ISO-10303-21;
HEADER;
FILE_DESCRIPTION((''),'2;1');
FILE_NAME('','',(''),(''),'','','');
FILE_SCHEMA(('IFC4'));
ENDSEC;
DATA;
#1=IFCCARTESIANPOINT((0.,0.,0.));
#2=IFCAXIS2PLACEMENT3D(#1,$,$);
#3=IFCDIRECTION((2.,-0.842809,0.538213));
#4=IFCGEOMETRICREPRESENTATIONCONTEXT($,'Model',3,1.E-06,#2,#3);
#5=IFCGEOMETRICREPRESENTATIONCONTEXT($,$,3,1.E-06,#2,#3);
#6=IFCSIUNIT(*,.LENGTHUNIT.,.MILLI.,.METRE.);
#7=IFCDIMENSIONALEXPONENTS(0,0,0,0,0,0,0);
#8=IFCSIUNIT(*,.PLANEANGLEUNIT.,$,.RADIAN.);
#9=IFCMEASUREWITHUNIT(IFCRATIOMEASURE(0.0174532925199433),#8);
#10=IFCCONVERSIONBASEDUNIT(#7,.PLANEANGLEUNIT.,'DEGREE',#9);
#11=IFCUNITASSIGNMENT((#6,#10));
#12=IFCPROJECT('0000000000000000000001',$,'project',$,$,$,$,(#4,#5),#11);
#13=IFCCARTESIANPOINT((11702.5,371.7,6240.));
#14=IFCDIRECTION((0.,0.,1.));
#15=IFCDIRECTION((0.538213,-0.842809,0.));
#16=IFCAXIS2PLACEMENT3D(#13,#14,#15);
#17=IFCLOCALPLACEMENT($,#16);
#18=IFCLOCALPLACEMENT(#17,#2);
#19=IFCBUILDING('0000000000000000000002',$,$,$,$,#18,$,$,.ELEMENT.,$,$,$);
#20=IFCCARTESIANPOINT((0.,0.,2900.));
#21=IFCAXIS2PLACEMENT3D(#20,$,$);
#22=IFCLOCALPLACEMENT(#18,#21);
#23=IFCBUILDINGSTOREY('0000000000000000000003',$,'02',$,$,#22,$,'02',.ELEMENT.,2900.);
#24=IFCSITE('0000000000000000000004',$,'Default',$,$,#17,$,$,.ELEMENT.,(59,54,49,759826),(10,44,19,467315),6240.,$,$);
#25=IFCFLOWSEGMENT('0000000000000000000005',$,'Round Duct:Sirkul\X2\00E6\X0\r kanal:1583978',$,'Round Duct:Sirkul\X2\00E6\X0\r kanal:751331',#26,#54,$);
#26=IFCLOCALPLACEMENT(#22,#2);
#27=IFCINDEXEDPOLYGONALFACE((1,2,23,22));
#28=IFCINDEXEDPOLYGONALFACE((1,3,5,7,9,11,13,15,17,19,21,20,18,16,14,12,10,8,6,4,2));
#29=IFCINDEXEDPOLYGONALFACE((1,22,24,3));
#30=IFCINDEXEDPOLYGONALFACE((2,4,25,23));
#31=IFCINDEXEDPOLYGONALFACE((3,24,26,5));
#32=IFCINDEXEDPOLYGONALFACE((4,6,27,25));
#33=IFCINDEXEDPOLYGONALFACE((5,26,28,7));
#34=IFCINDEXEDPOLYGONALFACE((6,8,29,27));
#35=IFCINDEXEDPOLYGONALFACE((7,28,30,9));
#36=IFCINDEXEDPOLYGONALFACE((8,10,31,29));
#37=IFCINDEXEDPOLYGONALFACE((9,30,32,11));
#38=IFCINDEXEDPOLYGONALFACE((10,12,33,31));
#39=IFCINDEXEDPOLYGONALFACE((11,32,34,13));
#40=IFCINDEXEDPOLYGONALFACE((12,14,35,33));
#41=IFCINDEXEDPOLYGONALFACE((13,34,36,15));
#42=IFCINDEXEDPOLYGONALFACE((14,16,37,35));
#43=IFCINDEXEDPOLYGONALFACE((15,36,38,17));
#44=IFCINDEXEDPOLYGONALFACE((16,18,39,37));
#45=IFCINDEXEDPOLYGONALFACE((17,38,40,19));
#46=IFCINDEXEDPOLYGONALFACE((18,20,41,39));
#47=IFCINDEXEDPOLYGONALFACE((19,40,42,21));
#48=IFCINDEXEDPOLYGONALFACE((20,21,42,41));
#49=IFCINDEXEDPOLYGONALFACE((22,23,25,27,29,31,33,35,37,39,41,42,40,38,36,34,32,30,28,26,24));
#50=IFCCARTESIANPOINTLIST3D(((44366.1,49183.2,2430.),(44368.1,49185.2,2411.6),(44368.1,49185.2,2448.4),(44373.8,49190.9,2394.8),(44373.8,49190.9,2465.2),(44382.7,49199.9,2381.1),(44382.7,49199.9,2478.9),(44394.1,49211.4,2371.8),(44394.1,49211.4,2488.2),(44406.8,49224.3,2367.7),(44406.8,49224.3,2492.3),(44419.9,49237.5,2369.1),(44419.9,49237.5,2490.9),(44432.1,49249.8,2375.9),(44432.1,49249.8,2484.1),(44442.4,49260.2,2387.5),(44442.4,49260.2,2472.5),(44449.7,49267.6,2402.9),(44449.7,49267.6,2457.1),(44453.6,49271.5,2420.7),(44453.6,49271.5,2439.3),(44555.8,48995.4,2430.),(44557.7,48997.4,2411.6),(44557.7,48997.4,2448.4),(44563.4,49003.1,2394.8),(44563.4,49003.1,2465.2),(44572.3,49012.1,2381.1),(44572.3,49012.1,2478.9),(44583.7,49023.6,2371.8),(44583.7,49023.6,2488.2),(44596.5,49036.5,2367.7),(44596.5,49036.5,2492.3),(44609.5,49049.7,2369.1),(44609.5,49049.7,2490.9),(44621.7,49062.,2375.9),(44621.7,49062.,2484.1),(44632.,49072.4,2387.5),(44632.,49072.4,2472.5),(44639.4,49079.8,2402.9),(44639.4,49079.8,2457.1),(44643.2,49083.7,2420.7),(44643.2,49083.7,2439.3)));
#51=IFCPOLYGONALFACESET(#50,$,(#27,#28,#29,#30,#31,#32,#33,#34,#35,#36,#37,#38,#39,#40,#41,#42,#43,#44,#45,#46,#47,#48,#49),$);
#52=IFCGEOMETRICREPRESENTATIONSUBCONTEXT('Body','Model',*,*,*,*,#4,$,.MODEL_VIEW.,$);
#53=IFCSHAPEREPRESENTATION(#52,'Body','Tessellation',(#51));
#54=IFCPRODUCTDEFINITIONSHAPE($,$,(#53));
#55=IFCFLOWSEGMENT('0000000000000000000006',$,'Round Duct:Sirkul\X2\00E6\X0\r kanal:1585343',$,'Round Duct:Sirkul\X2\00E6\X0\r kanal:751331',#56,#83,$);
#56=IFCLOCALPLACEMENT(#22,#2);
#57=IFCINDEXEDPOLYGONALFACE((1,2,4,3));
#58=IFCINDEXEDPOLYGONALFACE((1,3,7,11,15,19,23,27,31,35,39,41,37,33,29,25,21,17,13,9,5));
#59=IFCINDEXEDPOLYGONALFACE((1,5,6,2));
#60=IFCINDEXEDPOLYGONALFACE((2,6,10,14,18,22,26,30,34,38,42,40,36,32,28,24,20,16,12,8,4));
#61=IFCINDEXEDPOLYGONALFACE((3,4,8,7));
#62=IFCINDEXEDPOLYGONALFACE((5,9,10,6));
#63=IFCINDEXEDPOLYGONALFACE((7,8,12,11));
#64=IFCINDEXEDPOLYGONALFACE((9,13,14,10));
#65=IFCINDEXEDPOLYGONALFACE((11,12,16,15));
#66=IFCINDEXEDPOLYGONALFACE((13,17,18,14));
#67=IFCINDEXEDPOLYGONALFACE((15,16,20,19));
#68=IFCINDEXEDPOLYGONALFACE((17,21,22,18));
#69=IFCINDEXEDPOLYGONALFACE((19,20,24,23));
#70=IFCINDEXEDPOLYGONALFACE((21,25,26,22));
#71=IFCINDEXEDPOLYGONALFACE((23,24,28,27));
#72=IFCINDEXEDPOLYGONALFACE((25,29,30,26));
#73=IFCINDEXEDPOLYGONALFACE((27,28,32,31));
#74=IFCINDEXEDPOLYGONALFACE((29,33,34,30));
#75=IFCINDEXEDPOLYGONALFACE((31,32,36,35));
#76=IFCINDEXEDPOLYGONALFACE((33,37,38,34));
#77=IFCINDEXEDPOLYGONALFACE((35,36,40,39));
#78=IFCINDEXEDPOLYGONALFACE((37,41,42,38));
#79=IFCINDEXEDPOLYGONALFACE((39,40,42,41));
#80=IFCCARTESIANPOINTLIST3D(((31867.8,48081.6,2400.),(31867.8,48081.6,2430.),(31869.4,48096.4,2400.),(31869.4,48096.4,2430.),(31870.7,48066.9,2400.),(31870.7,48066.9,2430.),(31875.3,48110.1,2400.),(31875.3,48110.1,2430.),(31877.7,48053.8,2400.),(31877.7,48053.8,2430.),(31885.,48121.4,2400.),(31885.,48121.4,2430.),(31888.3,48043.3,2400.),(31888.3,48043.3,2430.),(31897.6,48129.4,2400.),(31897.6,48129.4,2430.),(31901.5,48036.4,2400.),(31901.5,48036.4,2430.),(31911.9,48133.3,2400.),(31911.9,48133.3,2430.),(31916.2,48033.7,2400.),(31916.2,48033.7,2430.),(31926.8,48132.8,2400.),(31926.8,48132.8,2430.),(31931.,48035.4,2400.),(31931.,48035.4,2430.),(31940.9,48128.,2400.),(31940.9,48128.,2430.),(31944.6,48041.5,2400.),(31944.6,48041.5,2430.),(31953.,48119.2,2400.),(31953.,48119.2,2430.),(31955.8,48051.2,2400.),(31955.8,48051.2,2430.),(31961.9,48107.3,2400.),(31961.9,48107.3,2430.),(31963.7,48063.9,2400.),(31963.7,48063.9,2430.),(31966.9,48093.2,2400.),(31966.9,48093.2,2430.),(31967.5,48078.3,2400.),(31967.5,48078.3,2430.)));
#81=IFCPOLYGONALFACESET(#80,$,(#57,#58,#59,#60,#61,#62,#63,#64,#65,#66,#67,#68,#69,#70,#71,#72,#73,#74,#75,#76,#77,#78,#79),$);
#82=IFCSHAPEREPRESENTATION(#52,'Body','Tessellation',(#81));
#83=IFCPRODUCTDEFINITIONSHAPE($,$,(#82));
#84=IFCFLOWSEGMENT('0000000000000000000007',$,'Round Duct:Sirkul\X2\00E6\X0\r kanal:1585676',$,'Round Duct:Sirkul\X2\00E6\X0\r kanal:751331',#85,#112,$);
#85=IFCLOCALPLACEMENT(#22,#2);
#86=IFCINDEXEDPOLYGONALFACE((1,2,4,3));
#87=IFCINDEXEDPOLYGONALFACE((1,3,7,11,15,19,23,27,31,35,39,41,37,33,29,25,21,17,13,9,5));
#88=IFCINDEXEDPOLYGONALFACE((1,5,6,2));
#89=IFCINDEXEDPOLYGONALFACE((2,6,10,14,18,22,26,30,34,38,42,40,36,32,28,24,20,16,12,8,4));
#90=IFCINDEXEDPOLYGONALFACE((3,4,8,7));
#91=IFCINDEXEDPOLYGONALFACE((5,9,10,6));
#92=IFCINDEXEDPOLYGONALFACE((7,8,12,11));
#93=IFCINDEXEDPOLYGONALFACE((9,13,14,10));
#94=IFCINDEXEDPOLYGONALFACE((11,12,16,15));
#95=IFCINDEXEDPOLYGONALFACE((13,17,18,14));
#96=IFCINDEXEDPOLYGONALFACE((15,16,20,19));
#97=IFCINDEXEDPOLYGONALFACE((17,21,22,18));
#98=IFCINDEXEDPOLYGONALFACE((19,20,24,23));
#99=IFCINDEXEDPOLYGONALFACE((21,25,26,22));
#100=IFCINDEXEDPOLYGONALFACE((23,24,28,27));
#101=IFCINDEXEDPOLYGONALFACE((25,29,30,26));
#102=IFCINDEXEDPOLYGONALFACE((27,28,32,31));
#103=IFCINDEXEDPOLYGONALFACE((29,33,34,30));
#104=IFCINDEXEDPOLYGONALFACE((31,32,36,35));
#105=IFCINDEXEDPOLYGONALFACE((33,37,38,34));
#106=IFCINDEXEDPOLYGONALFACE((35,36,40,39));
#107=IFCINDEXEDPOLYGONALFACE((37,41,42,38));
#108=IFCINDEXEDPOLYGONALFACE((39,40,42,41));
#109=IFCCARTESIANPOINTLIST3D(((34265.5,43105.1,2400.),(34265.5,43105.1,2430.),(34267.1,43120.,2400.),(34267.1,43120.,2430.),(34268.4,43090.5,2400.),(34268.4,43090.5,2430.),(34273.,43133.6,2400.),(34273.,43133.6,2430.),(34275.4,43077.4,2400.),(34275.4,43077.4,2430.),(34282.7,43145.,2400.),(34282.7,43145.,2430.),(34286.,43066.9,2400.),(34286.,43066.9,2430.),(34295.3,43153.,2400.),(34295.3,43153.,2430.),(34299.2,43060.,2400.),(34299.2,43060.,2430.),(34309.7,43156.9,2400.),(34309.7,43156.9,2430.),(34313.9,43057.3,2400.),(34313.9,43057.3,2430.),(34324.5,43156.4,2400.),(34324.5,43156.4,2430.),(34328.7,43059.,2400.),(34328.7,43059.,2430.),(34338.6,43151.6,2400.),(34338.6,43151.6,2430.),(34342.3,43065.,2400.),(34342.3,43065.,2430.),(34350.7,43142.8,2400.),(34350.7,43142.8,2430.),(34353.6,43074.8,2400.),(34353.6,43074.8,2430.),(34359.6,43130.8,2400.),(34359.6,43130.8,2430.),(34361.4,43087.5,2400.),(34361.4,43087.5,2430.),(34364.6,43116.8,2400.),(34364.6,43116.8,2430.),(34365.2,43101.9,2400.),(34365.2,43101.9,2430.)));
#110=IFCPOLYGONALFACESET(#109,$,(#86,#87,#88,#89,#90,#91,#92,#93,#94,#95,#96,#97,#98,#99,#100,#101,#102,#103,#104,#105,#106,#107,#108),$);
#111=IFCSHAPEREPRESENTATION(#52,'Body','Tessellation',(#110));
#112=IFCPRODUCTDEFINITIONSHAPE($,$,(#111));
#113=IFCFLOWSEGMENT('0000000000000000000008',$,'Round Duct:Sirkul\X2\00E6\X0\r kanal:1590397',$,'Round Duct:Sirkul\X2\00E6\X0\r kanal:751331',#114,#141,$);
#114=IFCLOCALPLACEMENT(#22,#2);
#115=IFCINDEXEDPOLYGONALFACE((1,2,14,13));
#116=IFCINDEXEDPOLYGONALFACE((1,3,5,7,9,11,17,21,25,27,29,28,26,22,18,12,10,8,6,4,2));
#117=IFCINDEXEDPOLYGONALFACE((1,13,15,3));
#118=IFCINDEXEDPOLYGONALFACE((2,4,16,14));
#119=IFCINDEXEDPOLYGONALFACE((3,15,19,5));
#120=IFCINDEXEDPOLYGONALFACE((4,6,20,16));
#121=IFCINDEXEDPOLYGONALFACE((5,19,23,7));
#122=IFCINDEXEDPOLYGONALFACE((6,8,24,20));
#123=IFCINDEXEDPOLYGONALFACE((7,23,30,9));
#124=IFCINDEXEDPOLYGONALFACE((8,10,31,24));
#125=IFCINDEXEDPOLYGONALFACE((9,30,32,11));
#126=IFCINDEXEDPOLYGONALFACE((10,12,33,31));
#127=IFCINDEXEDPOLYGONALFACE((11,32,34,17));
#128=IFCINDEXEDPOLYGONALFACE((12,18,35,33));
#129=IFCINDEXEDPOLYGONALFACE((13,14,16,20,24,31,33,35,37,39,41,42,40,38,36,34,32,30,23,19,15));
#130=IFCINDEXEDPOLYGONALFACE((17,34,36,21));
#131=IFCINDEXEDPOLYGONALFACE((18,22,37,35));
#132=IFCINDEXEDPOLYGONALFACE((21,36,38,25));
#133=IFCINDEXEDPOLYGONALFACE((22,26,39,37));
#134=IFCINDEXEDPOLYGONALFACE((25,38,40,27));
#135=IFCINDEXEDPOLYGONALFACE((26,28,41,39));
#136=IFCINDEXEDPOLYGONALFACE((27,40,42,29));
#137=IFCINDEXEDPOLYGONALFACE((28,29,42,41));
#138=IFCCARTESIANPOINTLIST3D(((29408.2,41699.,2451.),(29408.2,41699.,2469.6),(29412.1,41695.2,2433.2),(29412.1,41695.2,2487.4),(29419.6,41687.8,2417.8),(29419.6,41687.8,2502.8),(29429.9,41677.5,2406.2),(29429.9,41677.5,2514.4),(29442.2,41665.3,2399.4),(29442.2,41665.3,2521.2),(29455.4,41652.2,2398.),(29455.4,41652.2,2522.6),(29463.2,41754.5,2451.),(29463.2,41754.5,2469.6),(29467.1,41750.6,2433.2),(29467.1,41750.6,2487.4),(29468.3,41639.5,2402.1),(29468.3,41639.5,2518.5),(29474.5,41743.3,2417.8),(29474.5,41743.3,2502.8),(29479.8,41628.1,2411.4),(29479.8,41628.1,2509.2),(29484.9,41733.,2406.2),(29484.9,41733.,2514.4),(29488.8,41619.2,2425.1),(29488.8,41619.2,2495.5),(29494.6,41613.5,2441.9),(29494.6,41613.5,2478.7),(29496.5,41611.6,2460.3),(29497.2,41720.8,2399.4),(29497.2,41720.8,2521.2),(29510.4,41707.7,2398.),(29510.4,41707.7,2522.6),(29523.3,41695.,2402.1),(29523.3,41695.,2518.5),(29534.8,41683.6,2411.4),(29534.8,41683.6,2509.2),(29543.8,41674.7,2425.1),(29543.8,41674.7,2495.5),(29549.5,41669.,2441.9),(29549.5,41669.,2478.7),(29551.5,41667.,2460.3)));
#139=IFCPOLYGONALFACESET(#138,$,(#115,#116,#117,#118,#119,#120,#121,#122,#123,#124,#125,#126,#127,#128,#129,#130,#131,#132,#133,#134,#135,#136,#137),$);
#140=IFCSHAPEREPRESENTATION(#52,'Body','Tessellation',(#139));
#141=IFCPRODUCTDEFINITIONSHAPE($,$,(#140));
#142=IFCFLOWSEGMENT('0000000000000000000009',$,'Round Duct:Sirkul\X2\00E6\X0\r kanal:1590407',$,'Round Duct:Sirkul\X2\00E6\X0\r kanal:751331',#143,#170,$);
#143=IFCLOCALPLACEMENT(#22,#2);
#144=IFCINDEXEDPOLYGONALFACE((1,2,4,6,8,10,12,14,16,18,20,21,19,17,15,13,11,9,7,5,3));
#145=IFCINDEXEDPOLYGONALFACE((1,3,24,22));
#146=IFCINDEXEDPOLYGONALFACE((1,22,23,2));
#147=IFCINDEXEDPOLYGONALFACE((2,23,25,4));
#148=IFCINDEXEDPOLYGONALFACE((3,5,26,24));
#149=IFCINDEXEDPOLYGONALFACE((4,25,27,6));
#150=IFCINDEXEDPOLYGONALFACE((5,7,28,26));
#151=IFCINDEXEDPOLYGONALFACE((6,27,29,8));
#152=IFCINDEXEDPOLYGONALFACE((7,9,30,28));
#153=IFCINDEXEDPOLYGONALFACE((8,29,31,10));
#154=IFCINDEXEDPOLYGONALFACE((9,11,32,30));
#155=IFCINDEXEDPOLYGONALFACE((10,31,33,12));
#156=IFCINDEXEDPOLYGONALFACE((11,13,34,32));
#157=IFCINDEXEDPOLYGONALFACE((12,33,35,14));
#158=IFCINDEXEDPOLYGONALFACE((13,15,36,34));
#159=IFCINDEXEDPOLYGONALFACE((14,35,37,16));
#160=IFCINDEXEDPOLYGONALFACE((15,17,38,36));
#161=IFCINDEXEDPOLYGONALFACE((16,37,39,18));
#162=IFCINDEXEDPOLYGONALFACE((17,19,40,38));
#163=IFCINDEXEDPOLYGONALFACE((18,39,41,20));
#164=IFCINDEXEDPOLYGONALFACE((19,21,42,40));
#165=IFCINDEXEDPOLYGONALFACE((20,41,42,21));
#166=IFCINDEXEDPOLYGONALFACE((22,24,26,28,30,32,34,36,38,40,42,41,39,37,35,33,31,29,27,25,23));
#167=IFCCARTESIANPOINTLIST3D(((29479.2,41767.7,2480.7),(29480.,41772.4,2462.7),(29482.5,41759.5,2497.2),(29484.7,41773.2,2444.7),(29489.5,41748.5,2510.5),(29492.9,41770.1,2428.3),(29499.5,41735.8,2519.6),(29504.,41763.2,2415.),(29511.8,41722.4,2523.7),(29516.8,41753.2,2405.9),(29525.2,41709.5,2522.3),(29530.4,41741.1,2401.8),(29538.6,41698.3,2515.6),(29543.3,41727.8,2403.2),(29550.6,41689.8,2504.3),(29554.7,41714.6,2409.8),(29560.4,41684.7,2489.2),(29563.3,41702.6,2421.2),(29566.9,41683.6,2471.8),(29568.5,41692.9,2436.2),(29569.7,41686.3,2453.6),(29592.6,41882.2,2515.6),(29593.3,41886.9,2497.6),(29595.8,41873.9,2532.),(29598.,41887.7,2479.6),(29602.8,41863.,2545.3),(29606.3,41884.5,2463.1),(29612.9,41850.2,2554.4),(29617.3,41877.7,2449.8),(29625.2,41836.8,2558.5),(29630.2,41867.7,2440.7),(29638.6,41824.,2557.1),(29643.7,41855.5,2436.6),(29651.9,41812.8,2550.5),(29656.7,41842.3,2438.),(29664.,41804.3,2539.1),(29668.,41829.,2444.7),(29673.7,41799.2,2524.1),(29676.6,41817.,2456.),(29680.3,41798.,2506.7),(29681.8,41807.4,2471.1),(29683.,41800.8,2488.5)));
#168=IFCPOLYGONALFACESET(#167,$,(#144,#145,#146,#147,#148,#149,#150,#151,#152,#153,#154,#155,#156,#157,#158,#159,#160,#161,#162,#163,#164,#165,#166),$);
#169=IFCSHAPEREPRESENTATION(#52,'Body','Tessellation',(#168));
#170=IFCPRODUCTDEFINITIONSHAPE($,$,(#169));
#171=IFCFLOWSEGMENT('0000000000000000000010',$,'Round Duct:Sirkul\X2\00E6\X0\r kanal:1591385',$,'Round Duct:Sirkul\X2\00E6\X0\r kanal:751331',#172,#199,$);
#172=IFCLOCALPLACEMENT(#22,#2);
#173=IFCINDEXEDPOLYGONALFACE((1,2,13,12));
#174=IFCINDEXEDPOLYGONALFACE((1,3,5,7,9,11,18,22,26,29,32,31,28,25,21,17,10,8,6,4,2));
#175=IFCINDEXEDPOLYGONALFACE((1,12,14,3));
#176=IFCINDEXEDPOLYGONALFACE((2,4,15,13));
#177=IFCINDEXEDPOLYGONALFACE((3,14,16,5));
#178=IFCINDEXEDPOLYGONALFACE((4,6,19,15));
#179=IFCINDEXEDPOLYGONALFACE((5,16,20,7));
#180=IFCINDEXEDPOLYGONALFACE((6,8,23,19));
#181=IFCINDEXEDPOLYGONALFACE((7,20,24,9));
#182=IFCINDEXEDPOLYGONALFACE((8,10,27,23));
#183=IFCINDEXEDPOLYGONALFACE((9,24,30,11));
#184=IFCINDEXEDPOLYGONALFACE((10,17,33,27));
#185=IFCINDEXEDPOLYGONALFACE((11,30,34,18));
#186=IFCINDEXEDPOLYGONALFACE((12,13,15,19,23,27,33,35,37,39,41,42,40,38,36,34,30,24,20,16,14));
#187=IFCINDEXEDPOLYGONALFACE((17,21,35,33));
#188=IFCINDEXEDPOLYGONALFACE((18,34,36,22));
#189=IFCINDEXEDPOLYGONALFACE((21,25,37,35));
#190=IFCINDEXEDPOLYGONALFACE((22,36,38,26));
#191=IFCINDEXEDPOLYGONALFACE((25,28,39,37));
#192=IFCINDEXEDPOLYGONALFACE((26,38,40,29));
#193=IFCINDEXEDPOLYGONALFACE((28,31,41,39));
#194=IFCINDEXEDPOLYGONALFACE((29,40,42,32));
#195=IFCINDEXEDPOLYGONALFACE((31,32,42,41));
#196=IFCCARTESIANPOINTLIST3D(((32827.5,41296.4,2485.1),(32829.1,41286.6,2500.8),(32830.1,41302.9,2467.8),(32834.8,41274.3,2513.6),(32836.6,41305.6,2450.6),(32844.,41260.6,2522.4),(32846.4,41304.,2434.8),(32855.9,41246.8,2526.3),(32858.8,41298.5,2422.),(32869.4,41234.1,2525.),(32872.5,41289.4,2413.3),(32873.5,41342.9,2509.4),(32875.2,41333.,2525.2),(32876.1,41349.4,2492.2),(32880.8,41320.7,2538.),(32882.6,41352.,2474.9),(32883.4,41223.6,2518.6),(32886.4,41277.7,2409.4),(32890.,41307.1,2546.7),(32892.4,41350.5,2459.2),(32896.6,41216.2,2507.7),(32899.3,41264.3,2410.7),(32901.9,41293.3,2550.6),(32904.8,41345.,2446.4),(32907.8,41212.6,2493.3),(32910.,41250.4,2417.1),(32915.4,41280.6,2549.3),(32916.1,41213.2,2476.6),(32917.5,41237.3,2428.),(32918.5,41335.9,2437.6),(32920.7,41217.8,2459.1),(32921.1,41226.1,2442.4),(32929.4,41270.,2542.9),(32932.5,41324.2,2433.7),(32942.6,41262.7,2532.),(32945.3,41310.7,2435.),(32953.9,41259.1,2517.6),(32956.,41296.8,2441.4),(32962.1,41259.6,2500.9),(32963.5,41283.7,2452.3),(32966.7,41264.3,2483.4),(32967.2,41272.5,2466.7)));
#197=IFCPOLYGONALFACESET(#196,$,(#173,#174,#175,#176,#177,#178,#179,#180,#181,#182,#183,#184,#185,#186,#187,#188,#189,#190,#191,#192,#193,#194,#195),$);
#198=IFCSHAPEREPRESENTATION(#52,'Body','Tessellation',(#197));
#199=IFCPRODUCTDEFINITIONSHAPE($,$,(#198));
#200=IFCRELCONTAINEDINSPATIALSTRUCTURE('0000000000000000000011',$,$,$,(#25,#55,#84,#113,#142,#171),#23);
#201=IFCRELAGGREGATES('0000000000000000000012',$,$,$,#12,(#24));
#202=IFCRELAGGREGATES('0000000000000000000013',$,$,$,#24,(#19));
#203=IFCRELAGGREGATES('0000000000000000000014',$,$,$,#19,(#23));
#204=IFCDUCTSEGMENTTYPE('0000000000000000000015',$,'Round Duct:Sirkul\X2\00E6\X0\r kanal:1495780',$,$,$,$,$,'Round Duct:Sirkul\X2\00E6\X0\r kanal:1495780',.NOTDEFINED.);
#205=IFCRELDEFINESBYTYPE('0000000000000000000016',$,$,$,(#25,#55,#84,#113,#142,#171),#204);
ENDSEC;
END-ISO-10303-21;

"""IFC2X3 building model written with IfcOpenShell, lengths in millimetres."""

from ifc_helpers import new_model, entity, si_unit, converted_unit, direction, frame, frame_2d, origin, origin_2d_with_axis, place, context, subcontext, project, spatial, circle, extrude, type_object, element, save


model = new_model("IFC2X3")

# Units and contexts
model_context = context("Model", 3, precision=1e-06, world=origin(), true_north=direction((2.0, -0.842809, 0.538213)))
context_of_model = context(None, 3, precision=1e-06, world=origin(), true_north=direction((2.0, -0.842809, 0.538213)))
body_context = subcontext(model_context, "Body", "Model", "MODEL_VIEW")
ifc_project = project(units=[si_unit("LENGTHUNIT", "METRE", prefix="MILLI"), converted_unit("PLANEANGLEUNIT", "DEGREE", entity("IfcRatioMeasure", 0.0174532925199433), si_unit("PLANEANGLEUNIT", "RADIAN"), dimensions=[0, 0, 0, 0, 0, 0, 0])], contexts=[model_context, context_of_model])

# Site, building, storey
site_placement = place(None, frame((11702.5, 371.7, 6240.0), z_axis=(0.0, 0.0, 1.0), x_axis=(0.538213, -0.842809, 0.0)))
site = spatial("IfcSite", under=ifc_project, at=site_placement, Name="Default", CompositionType="ELEMENT", RefLatitude=(59, 54, 49, 759826), RefLongitude=(10, 44, 19, 467315), RefElevation=6240.0)
building_placement = place(site_placement, origin())
building = spatial("IfcBuilding", under=site, at=building_placement, CompositionType="ELEMENT")
storey_placement = place(building_placement, frame((0.0, 0.0, 2900.0)))
storey = spatial("IfcBuildingStorey", under=building, at=storey_placement, Name="02", LongName="02", CompositionType="ELEMENT", Elevation=2900.0)

# Flow segments
duct_segment_type = type_object("IfcDuctSegmentType", Name="Round Duct:Sirkulær kanal:1495780", ElementType="Round Duct:Sirkulær kanal:1495780", PredefinedType="NOTDEFINED")
flow_segment_1_placement = place(storey_placement, origin())
element("IfcFlowSegment", 1, at=flow_segment_1_placement, inside=storey, type_object=duct_segment_type, Name="Round Duct:Sirkulær kanal:1583978", ObjectType="Round Duct:Sirkulær kanal:751331", context=body_context, shape_type="SweptSolid", body=[
    extrude(circle(Radius=62.5, at=origin_2d_with_axis()), frame((44410.1, 49227.6, 2430.0), z_axis=(0.710534, -0.703662, 0.0), x_axis=(-0.703662, -0.710534, 0.0)), (0.0, 0.0, 1.0), 266.9),
])
flow_segment_2_placement = place(storey_placement, origin())
element("IfcFlowSegment", 2, at=flow_segment_2_placement, inside=storey, type_object=duct_segment_type, Name="Round Duct:Sirkulær kanal:1585343", ObjectType="Round Duct:Sirkulær kanal:751331", context=body_context, shape_type="SweptSolid", body=[
    extrude(circle(Radius=50.0, at=frame_2d((0.0, 0.0), x_axis=(1.0, 0.0))), frame((31917.8, 48083.7, 2400.0), z_axis=(0.0, 0.0, 1.0), x_axis=(0.703643, 0.710554, 0.0)), (0.0, 0.0, 1.0), 30.0),
])
flow_segment_3_placement = place(storey_placement, origin())
element("IfcFlowSegment", 3, at=flow_segment_3_placement, inside=storey, type_object=duct_segment_type, Name="Round Duct:Sirkulær kanal:1585676", ObjectType="Round Duct:Sirkulær kanal:751331", context=body_context, shape_type="SweptSolid", body=[
    extrude(circle(Radius=50.0, at=frame_2d((0.0, 0.0), x_axis=(1.0, 0.0))), frame((34315.5, 43107.2, 2400.0), z_axis=(0.0, 0.0, 1.0), x_axis=(0.703643, 0.710554, 0.0)), (0.0, 0.0, 1.0), 30.0),
])
flow_segment_4_placement = place(storey_placement, origin())
element("IfcFlowSegment", 4, at=flow_segment_4_placement, inside=storey, type_object=duct_segment_type, Name="Round Duct:Sirkulær kanal:1590397", ObjectType="Round Duct:Sirkulær kanal:751331", context=body_context, shape_type="SweptSolid", body=[
    extrude(circle(Radius=62.5, at=origin_2d_with_axis()), frame((29452.1, 41655.5, 2460.3), z_axis=(0.703643, 0.710554, 0.0), x_axis=(0.710554, -0.703643, 0.0)), (0.0, 0.0, 1.0), 78.1),
])
flow_segment_5_placement = place(storey_placement, origin())
element("IfcFlowSegment", 5, at=flow_segment_5_placement, inside=storey, type_object=duct_segment_type, Name="Round Duct:Sirkulær kanal:1590407", ObjectType="Round Duct:Sirkulær kanal:751331", context=body_context, shape_type="SweptSolid", body=[
    extrude(circle(Radius=62.5, at=frame_2d((0.0, 0.0), x_axis=(1.0, 0.0))), frame((29524.4, 41728.4, 2462.7), z_axis=(0.687729, 0.694535, 0.211304), x_axis=(-0.71058, 0.703617, 0.0)), (0.0, 0.0, 1.0), 164.8),
])
flow_segment_6_placement = place(storey_placement, origin())
element("IfcFlowSegment", 6, at=flow_segment_6_placement, inside=storey, type_object=duct_segment_type, Name="Round Duct:Sirkulær kanal:1591385", ObjectType="Round Duct:Sirkulær kanal:751331", context=body_context, shape_type="SweptSolid", body=[
    extrude(circle(Radius=62.5, at=frame_2d((0.0, 0.0), x_axis=(1.0, 0.0))), frame((32874.5, 41259.0, 2467.8), z_axis=(0.65951, 0.665987, 0.34858), x_axis=(-0.710554, 0.703643, 0.0)), (0.0, 0.0, 1.0), 69.8),
])

save(model, "model.ifc")
